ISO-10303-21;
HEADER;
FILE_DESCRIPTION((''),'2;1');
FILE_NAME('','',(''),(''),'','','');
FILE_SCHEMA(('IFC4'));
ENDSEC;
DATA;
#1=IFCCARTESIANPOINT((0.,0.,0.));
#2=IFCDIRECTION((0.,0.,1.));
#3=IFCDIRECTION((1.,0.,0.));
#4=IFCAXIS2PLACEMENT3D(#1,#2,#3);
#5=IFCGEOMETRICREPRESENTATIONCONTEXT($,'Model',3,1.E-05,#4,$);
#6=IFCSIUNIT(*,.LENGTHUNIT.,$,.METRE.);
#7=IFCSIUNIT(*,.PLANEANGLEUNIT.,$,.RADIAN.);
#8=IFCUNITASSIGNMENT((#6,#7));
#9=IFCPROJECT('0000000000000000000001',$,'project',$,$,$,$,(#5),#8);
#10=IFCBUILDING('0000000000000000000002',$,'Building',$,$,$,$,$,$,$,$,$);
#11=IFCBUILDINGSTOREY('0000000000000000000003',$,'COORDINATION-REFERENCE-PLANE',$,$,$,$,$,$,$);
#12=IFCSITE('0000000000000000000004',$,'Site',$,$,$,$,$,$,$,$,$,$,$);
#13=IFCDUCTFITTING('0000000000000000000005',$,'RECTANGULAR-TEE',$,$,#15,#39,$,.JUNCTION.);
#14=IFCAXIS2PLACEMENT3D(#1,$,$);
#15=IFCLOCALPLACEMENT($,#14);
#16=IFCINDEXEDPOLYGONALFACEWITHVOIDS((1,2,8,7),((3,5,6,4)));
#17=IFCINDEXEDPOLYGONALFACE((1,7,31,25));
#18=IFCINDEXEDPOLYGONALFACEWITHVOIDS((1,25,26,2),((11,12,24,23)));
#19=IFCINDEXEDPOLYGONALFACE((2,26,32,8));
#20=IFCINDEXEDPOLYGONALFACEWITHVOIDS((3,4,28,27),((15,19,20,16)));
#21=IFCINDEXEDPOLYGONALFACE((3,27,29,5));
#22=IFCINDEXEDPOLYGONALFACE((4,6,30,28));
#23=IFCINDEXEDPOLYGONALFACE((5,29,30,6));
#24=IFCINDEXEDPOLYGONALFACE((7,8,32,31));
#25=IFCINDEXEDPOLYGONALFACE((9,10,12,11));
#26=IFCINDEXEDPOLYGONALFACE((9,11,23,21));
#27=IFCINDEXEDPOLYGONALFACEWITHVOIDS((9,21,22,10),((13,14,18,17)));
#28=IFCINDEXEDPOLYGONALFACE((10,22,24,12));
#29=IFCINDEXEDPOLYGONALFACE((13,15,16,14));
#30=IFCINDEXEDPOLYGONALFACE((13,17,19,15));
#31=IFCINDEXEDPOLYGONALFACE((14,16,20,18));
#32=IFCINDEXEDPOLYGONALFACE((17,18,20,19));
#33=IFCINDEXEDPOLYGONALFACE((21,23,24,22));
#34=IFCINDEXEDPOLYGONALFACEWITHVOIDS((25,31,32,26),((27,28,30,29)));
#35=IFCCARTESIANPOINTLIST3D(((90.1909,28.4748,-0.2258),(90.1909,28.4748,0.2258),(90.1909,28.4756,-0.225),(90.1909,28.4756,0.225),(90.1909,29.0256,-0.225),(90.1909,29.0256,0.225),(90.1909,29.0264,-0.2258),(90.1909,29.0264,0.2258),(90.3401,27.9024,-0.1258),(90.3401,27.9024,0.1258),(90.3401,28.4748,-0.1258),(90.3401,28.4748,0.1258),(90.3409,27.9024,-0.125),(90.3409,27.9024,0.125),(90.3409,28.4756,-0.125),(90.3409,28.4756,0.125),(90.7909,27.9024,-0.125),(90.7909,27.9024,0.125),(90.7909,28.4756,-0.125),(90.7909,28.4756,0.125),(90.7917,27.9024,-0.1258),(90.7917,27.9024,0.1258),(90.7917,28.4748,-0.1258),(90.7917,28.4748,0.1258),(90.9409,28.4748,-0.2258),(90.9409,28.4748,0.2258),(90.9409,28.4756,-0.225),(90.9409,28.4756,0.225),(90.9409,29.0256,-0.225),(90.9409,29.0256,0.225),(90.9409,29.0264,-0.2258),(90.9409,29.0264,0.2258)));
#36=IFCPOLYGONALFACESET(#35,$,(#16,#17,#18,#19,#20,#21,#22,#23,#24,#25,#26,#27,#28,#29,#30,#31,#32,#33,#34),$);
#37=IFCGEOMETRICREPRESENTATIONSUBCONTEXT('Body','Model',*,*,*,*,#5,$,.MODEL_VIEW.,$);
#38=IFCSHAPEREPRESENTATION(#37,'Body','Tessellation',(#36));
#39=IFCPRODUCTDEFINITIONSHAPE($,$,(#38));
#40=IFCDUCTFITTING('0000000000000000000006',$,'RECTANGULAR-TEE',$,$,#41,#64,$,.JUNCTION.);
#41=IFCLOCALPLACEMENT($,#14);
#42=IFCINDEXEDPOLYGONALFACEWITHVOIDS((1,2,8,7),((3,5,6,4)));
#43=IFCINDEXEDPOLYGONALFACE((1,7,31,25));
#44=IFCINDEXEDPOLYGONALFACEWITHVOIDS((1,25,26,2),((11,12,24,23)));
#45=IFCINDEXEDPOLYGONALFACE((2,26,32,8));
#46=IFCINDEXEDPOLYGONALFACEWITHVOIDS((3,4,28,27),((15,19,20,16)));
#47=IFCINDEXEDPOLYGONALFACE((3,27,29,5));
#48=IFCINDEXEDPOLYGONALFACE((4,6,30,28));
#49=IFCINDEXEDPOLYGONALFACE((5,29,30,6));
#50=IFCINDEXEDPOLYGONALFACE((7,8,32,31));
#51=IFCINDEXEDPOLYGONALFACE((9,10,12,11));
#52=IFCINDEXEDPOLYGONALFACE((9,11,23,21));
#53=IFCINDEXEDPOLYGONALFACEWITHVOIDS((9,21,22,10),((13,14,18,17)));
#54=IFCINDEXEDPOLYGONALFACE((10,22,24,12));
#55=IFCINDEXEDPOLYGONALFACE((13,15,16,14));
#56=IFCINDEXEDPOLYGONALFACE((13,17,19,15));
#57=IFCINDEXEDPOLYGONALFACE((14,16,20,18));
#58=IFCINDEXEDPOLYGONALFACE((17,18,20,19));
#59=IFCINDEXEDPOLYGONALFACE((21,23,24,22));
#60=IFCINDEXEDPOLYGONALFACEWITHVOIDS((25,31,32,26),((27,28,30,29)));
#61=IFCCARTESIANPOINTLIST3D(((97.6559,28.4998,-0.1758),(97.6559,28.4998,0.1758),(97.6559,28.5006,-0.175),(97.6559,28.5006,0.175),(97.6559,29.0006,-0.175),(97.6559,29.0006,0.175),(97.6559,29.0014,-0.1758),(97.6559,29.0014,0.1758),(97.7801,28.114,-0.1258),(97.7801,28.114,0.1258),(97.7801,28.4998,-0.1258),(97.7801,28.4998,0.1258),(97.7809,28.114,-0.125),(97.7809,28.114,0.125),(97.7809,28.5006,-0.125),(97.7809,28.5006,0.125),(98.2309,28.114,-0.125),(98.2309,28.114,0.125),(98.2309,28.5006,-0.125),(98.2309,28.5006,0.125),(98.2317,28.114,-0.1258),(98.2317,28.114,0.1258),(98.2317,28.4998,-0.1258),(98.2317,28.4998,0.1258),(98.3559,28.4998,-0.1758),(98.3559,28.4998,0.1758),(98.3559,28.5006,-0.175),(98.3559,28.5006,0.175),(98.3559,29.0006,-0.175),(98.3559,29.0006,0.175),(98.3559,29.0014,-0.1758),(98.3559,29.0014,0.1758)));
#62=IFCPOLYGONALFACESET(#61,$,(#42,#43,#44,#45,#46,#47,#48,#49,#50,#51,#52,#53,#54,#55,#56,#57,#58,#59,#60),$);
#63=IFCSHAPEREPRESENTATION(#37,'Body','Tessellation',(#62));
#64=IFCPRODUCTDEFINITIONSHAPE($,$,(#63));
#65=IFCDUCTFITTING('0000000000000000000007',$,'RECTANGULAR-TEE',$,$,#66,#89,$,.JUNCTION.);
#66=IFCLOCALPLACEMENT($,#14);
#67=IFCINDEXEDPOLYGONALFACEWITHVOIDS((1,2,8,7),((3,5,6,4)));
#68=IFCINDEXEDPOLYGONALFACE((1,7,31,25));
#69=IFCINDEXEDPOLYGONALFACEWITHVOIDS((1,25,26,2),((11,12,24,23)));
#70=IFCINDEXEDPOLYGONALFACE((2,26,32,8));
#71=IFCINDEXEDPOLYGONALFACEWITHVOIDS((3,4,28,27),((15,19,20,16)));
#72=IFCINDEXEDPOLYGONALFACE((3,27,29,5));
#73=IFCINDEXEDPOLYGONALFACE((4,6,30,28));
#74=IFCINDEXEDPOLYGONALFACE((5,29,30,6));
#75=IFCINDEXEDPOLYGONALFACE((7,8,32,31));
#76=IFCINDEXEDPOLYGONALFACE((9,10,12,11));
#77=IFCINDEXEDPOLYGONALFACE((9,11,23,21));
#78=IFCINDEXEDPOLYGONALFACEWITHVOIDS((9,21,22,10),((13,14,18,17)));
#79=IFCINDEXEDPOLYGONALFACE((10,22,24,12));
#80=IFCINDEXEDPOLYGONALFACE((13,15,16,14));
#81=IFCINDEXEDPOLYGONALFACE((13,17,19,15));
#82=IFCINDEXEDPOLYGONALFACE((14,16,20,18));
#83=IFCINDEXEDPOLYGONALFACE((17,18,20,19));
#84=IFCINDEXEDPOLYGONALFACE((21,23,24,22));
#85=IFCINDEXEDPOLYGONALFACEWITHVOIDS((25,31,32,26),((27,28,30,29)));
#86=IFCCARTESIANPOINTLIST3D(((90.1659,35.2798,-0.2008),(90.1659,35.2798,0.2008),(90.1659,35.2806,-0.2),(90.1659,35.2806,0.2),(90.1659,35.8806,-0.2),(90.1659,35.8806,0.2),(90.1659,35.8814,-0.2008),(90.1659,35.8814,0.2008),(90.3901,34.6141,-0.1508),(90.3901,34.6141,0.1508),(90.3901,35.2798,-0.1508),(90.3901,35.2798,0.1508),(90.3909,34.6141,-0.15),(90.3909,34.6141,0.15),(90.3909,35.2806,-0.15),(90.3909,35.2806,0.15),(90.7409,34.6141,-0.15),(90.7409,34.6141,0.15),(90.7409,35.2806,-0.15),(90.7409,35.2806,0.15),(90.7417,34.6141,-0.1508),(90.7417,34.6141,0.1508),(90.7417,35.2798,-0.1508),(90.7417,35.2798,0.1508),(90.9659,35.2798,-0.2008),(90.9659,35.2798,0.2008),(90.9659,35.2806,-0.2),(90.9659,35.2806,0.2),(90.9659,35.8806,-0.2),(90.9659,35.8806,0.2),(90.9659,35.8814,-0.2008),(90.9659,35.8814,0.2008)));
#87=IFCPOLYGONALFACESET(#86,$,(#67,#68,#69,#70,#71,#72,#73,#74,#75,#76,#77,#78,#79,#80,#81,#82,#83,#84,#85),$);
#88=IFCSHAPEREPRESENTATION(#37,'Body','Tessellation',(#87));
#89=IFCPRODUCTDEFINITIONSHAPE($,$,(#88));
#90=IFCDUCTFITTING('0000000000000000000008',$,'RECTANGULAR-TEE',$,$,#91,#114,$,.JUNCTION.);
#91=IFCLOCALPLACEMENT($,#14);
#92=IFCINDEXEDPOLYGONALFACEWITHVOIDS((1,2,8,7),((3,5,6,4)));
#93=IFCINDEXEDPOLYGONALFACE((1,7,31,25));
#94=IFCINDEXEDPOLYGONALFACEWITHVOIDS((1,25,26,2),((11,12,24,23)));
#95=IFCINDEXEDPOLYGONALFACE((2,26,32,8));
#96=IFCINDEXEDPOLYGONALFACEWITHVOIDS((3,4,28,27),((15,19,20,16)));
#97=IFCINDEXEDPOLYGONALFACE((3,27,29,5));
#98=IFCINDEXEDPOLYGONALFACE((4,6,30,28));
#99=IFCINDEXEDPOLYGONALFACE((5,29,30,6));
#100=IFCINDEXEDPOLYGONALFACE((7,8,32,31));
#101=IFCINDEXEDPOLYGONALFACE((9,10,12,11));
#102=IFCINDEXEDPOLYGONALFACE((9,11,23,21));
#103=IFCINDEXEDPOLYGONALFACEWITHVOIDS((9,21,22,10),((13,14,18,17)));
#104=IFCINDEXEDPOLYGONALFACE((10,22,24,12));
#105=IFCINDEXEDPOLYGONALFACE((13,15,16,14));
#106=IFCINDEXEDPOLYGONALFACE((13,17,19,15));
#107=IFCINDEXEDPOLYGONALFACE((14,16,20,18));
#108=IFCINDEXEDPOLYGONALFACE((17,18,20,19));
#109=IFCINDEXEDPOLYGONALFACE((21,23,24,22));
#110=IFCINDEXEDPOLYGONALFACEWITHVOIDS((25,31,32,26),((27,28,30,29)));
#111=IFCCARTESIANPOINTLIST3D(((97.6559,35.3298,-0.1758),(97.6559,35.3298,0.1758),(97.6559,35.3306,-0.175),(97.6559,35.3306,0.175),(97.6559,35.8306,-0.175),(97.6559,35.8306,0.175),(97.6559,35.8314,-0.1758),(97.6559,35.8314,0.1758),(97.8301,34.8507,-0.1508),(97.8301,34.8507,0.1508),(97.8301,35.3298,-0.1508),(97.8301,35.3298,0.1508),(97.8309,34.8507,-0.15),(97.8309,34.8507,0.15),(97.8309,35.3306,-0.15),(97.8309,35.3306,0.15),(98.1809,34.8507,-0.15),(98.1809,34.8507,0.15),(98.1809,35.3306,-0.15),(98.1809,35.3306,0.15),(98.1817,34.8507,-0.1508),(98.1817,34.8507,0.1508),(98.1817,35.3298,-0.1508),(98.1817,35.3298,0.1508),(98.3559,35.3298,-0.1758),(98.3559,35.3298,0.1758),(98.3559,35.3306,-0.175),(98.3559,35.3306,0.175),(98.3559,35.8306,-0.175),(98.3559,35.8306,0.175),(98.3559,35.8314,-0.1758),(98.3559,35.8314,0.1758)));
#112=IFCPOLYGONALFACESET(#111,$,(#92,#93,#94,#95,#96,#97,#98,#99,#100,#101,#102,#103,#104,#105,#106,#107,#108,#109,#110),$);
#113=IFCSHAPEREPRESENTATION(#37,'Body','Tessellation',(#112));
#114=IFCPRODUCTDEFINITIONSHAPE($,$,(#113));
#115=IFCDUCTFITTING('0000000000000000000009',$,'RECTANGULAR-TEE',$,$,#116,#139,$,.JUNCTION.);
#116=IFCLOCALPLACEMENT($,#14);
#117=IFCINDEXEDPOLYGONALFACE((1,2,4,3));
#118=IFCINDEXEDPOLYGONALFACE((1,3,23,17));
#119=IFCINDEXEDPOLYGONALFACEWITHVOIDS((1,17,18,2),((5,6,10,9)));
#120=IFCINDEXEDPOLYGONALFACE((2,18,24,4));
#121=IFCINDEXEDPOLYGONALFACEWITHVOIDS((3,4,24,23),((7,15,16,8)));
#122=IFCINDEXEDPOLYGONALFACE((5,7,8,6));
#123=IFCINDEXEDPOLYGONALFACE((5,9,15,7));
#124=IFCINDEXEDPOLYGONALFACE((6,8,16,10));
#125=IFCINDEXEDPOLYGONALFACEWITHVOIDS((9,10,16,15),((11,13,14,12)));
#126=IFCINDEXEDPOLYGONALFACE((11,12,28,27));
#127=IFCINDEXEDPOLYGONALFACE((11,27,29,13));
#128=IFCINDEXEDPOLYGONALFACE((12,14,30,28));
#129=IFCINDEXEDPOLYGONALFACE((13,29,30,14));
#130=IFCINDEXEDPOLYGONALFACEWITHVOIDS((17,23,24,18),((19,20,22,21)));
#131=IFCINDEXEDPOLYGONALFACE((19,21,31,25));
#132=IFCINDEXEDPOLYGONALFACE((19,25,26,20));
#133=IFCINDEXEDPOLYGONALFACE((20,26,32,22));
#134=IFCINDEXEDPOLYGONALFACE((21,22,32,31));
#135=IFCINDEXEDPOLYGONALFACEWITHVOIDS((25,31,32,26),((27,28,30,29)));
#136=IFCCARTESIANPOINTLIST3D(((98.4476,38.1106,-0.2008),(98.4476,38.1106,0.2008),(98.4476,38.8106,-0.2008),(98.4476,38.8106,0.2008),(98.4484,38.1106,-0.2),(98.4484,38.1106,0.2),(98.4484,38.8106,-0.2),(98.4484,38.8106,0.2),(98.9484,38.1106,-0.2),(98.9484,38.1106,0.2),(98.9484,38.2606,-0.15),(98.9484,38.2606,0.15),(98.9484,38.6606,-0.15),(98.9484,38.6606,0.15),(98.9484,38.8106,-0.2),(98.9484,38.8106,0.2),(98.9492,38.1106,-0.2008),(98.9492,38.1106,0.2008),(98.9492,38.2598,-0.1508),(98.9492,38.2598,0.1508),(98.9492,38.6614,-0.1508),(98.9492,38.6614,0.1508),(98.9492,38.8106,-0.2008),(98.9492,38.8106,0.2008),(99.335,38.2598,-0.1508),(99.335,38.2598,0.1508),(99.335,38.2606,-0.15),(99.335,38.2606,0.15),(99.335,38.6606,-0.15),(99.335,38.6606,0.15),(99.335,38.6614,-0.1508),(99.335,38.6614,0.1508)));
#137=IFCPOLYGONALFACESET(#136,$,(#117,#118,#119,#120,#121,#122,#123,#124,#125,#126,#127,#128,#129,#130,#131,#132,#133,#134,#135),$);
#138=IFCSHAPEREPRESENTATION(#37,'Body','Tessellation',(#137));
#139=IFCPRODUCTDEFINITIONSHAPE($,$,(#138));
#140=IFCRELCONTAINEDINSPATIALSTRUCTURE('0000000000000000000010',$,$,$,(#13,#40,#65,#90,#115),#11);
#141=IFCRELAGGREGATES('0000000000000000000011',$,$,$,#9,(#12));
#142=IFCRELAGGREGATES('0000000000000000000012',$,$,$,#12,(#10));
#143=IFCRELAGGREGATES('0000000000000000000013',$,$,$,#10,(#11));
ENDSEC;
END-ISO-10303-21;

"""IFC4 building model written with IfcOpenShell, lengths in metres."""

from ifc_helpers import new_model, si_unit, frame, origin_with_axes, place, context, subcontext, project, spatial, rectangle, extrude, boolean, element, save


model = new_model("IFC4")

# Units and contexts
model_context = context("Model", 3, precision=1e-05, world=origin_with_axes())
body_context = subcontext(model_context, "Body", "Model", "MODEL_VIEW")
ifc_project = project(units=[si_unit("LENGTHUNIT", "METRE"), si_unit("PLANEANGLEUNIT", "RADIAN")], contexts=[model_context])

# Site, building, storey
site = spatial("IfcSite", under=ifc_project, Name="Site")
building = spatial("IfcBuilding", under=site, Name="Building")
storey = spatial("IfcBuildingStorey", under=building, Name="COORDINATION-REFERENCE-PLANE")

# Duct fittings
duct_fitting_1_placement = place(None, frame((90.5659, 28.7506, 0.0), z_axis=(1.0, 0.0, 0.0), x_axis=(0.0, -1.0, 0.0)))
solid_1 = boolean("UNION", extrude(rectangle(XDim=0.55, YDim=0.45), frame((0.0, 0.0, -0.375), z_axis=(0.0, 0.0, 1.0), x_axis=(1.0, 0.0, 0.0)), (0.0, 0.0, 1.0), 0.75), extrude(rectangle(XDim=0.45, YDim=0.25), frame((0.0, 0.0, 0.0), z_axis=(1.0, 0.0, 0.0), x_axis=(0.0, 0.0, -1.0)), (0.0, 0.0, 1.0), 0.8482))
element("IfcDuctFitting", 1, at=duct_fitting_1_placement, inside=storey, Name="RECTANGULAR-TEE", PredefinedType="JUNCTION", context=body_context, shape_type="CSG", body=[
    boolean("DIFFERENCE", boolean("UNION", extrude(rectangle(XDim=0.5516, YDim=0.4516), frame((0.0, 0.0, -0.375), z_axis=(0.0, 0.0, 1.0), x_axis=(1.0, 0.0, 0.0)), (0.0, 0.0, 1.0), 0.75), extrude(rectangle(XDim=0.4516, YDim=0.2516), frame((0.0, 0.0, 0.0), z_axis=(1.0, 0.0, 0.0), x_axis=(0.0, 0.0, -1.0)), (0.0, 0.0, 1.0), 0.8482)), solid_1),
])
duct_fitting_2_placement = place(None, frame((98.0059, 28.7506, 0.0), z_axis=(1.0, 0.0, 0.0), x_axis=(0.0, -1.0, 0.0)))
solid_2 = boolean("UNION", extrude(rectangle(XDim=0.5, YDim=0.35), frame((0.0, 0.0, -0.35), z_axis=(0.0, 0.0, 1.0), x_axis=(1.0, 0.0, 0.0)), (0.0, 0.0, 1.0), 0.7), extrude(rectangle(XDim=0.45, YDim=0.25), frame((0.0, 0.0, 0.0), z_axis=(1.0, 0.0, 0.0), x_axis=(0.0, 0.0, -1.0)), (0.0, 0.0, 1.0), 0.6366))
element("IfcDuctFitting", 2, at=duct_fitting_2_placement, inside=storey, Name="RECTANGULAR-TEE", PredefinedType="JUNCTION", context=body_context, shape_type="CSG", body=[
    boolean("DIFFERENCE", boolean("UNION", extrude(rectangle(XDim=0.5016, YDim=0.3516), frame((0.0, 0.0, -0.35), z_axis=(0.0, 0.0, 1.0), x_axis=(1.0, 0.0, 0.0)), (0.0, 0.0, 1.0), 0.7), extrude(rectangle(XDim=0.4516, YDim=0.2516), frame((0.0, 0.0, 0.0), z_axis=(1.0, 0.0, 0.0), x_axis=(0.0, 0.0, -1.0)), (0.0, 0.0, 1.0), 0.6366)), solid_2),
])
duct_fitting_3_placement = place(None, frame((90.5659, 35.5806, 0.0), z_axis=(1.0, 0.0, 0.0), x_axis=(0.0, -1.0, 0.0)))
solid_3 = boolean("UNION", extrude(rectangle(XDim=0.6, YDim=0.4), frame((0.0, 0.0, -0.4), z_axis=(0.0, 0.0, 1.0), x_axis=(1.0, 0.0, 0.0)), (0.0, 0.0, 1.0), 0.8), extrude(rectangle(XDim=0.35, YDim=0.3), frame((0.0, 0.0, 0.0), z_axis=(1.0, 0.0, 0.0), x_axis=(0.0, 0.0, -1.0)), (0.0, 0.0, 1.0), 0.9665))
element("IfcDuctFitting", 3, at=duct_fitting_3_placement, inside=storey, Name="RECTANGULAR-TEE", PredefinedType="JUNCTION", context=body_context, shape_type="CSG", body=[
    boolean("DIFFERENCE", boolean("UNION", extrude(rectangle(XDim=0.6016, YDim=0.4016), frame((0.0, 0.0, -0.4), z_axis=(0.0, 0.0, 1.0), x_axis=(1.0, 0.0, 0.0)), (0.0, 0.0, 1.0), 0.8), extrude(rectangle(XDim=0.3516, YDim=0.3016), frame((0.0, 0.0, 0.0), z_axis=(1.0, 0.0, 0.0), x_axis=(0.0, 0.0, -1.0)), (0.0, 0.0, 1.0), 0.9665)), solid_3),
])
duct_fitting_4_placement = place(None, frame((98.0059, 35.5806, 0.0), z_axis=(1.0, 0.0, 0.0), x_axis=(0.0, -1.0, 0.0)))
solid_4 = boolean("UNION", extrude(rectangle(XDim=0.5, YDim=0.35), frame((0.0, 0.0, -0.35), z_axis=(0.0, 0.0, 1.0), x_axis=(1.0, 0.0, 0.0)), (0.0, 0.0, 1.0), 0.7), extrude(rectangle(XDim=0.35, YDim=0.3), frame((0.0, 0.0, 0.0), z_axis=(1.0, 0.0, 0.0), x_axis=(0.0, 0.0, -1.0)), (0.0, 0.0, 1.0), 0.7299))
element("IfcDuctFitting", 4, at=duct_fitting_4_placement, inside=storey, Name="RECTANGULAR-TEE", PredefinedType="JUNCTION", context=body_context, shape_type="CSG", body=[
    boolean("DIFFERENCE", boolean("UNION", extrude(rectangle(XDim=0.5016, YDim=0.3516), frame((0.0, 0.0, -0.35), z_axis=(0.0, 0.0, 1.0), x_axis=(1.0, 0.0, 0.0)), (0.0, 0.0, 1.0), 0.7), extrude(rectangle(XDim=0.3516, YDim=0.3016), frame((0.0, 0.0, 0.0), z_axis=(1.0, 0.0, 0.0), x_axis=(0.0, 0.0, -1.0)), (0.0, 0.0, 1.0), 0.7299)), solid_4),
])
duct_fitting_5_placement = place(None, frame((98.6984, 38.4606, 0.0), z_axis=(0.0, 1.0, 0.0), x_axis=(1.0, 0.0, 0.0)))
solid_5 = boolean("UNION", extrude(rectangle(XDim=0.5, YDim=0.4), frame((0.0, 0.0, -0.35), z_axis=(0.0, 0.0, 1.0), x_axis=(1.0, 0.0, 0.0)), (0.0, 0.0, 1.0), 0.7), extrude(rectangle(XDim=0.4, YDim=0.3), frame((0.0, 0.0, 0.0), z_axis=(1.0, 0.0, 0.0), x_axis=(0.0, 0.0, -1.0)), (0.0, 0.0, 1.0), 0.6366))
element("IfcDuctFitting", 5, at=duct_fitting_5_placement, inside=storey, Name="RECTANGULAR-TEE", PredefinedType="JUNCTION", context=body_context, shape_type="CSG", body=[
    boolean("DIFFERENCE", boolean("UNION", extrude(rectangle(XDim=0.5016, YDim=0.4016), frame((0.0, 0.0, -0.35), z_axis=(0.0, 0.0, 1.0), x_axis=(1.0, 0.0, 0.0)), (0.0, 0.0, 1.0), 0.7), extrude(rectangle(XDim=0.4016, YDim=0.3016), frame((0.0, 0.0, 0.0), z_axis=(1.0, 0.0, 0.0), x_axis=(0.0, 0.0, -1.0)), (0.0, 0.0, 1.0), 0.6366)), solid_5),
])

save(model, "model.ifc")
